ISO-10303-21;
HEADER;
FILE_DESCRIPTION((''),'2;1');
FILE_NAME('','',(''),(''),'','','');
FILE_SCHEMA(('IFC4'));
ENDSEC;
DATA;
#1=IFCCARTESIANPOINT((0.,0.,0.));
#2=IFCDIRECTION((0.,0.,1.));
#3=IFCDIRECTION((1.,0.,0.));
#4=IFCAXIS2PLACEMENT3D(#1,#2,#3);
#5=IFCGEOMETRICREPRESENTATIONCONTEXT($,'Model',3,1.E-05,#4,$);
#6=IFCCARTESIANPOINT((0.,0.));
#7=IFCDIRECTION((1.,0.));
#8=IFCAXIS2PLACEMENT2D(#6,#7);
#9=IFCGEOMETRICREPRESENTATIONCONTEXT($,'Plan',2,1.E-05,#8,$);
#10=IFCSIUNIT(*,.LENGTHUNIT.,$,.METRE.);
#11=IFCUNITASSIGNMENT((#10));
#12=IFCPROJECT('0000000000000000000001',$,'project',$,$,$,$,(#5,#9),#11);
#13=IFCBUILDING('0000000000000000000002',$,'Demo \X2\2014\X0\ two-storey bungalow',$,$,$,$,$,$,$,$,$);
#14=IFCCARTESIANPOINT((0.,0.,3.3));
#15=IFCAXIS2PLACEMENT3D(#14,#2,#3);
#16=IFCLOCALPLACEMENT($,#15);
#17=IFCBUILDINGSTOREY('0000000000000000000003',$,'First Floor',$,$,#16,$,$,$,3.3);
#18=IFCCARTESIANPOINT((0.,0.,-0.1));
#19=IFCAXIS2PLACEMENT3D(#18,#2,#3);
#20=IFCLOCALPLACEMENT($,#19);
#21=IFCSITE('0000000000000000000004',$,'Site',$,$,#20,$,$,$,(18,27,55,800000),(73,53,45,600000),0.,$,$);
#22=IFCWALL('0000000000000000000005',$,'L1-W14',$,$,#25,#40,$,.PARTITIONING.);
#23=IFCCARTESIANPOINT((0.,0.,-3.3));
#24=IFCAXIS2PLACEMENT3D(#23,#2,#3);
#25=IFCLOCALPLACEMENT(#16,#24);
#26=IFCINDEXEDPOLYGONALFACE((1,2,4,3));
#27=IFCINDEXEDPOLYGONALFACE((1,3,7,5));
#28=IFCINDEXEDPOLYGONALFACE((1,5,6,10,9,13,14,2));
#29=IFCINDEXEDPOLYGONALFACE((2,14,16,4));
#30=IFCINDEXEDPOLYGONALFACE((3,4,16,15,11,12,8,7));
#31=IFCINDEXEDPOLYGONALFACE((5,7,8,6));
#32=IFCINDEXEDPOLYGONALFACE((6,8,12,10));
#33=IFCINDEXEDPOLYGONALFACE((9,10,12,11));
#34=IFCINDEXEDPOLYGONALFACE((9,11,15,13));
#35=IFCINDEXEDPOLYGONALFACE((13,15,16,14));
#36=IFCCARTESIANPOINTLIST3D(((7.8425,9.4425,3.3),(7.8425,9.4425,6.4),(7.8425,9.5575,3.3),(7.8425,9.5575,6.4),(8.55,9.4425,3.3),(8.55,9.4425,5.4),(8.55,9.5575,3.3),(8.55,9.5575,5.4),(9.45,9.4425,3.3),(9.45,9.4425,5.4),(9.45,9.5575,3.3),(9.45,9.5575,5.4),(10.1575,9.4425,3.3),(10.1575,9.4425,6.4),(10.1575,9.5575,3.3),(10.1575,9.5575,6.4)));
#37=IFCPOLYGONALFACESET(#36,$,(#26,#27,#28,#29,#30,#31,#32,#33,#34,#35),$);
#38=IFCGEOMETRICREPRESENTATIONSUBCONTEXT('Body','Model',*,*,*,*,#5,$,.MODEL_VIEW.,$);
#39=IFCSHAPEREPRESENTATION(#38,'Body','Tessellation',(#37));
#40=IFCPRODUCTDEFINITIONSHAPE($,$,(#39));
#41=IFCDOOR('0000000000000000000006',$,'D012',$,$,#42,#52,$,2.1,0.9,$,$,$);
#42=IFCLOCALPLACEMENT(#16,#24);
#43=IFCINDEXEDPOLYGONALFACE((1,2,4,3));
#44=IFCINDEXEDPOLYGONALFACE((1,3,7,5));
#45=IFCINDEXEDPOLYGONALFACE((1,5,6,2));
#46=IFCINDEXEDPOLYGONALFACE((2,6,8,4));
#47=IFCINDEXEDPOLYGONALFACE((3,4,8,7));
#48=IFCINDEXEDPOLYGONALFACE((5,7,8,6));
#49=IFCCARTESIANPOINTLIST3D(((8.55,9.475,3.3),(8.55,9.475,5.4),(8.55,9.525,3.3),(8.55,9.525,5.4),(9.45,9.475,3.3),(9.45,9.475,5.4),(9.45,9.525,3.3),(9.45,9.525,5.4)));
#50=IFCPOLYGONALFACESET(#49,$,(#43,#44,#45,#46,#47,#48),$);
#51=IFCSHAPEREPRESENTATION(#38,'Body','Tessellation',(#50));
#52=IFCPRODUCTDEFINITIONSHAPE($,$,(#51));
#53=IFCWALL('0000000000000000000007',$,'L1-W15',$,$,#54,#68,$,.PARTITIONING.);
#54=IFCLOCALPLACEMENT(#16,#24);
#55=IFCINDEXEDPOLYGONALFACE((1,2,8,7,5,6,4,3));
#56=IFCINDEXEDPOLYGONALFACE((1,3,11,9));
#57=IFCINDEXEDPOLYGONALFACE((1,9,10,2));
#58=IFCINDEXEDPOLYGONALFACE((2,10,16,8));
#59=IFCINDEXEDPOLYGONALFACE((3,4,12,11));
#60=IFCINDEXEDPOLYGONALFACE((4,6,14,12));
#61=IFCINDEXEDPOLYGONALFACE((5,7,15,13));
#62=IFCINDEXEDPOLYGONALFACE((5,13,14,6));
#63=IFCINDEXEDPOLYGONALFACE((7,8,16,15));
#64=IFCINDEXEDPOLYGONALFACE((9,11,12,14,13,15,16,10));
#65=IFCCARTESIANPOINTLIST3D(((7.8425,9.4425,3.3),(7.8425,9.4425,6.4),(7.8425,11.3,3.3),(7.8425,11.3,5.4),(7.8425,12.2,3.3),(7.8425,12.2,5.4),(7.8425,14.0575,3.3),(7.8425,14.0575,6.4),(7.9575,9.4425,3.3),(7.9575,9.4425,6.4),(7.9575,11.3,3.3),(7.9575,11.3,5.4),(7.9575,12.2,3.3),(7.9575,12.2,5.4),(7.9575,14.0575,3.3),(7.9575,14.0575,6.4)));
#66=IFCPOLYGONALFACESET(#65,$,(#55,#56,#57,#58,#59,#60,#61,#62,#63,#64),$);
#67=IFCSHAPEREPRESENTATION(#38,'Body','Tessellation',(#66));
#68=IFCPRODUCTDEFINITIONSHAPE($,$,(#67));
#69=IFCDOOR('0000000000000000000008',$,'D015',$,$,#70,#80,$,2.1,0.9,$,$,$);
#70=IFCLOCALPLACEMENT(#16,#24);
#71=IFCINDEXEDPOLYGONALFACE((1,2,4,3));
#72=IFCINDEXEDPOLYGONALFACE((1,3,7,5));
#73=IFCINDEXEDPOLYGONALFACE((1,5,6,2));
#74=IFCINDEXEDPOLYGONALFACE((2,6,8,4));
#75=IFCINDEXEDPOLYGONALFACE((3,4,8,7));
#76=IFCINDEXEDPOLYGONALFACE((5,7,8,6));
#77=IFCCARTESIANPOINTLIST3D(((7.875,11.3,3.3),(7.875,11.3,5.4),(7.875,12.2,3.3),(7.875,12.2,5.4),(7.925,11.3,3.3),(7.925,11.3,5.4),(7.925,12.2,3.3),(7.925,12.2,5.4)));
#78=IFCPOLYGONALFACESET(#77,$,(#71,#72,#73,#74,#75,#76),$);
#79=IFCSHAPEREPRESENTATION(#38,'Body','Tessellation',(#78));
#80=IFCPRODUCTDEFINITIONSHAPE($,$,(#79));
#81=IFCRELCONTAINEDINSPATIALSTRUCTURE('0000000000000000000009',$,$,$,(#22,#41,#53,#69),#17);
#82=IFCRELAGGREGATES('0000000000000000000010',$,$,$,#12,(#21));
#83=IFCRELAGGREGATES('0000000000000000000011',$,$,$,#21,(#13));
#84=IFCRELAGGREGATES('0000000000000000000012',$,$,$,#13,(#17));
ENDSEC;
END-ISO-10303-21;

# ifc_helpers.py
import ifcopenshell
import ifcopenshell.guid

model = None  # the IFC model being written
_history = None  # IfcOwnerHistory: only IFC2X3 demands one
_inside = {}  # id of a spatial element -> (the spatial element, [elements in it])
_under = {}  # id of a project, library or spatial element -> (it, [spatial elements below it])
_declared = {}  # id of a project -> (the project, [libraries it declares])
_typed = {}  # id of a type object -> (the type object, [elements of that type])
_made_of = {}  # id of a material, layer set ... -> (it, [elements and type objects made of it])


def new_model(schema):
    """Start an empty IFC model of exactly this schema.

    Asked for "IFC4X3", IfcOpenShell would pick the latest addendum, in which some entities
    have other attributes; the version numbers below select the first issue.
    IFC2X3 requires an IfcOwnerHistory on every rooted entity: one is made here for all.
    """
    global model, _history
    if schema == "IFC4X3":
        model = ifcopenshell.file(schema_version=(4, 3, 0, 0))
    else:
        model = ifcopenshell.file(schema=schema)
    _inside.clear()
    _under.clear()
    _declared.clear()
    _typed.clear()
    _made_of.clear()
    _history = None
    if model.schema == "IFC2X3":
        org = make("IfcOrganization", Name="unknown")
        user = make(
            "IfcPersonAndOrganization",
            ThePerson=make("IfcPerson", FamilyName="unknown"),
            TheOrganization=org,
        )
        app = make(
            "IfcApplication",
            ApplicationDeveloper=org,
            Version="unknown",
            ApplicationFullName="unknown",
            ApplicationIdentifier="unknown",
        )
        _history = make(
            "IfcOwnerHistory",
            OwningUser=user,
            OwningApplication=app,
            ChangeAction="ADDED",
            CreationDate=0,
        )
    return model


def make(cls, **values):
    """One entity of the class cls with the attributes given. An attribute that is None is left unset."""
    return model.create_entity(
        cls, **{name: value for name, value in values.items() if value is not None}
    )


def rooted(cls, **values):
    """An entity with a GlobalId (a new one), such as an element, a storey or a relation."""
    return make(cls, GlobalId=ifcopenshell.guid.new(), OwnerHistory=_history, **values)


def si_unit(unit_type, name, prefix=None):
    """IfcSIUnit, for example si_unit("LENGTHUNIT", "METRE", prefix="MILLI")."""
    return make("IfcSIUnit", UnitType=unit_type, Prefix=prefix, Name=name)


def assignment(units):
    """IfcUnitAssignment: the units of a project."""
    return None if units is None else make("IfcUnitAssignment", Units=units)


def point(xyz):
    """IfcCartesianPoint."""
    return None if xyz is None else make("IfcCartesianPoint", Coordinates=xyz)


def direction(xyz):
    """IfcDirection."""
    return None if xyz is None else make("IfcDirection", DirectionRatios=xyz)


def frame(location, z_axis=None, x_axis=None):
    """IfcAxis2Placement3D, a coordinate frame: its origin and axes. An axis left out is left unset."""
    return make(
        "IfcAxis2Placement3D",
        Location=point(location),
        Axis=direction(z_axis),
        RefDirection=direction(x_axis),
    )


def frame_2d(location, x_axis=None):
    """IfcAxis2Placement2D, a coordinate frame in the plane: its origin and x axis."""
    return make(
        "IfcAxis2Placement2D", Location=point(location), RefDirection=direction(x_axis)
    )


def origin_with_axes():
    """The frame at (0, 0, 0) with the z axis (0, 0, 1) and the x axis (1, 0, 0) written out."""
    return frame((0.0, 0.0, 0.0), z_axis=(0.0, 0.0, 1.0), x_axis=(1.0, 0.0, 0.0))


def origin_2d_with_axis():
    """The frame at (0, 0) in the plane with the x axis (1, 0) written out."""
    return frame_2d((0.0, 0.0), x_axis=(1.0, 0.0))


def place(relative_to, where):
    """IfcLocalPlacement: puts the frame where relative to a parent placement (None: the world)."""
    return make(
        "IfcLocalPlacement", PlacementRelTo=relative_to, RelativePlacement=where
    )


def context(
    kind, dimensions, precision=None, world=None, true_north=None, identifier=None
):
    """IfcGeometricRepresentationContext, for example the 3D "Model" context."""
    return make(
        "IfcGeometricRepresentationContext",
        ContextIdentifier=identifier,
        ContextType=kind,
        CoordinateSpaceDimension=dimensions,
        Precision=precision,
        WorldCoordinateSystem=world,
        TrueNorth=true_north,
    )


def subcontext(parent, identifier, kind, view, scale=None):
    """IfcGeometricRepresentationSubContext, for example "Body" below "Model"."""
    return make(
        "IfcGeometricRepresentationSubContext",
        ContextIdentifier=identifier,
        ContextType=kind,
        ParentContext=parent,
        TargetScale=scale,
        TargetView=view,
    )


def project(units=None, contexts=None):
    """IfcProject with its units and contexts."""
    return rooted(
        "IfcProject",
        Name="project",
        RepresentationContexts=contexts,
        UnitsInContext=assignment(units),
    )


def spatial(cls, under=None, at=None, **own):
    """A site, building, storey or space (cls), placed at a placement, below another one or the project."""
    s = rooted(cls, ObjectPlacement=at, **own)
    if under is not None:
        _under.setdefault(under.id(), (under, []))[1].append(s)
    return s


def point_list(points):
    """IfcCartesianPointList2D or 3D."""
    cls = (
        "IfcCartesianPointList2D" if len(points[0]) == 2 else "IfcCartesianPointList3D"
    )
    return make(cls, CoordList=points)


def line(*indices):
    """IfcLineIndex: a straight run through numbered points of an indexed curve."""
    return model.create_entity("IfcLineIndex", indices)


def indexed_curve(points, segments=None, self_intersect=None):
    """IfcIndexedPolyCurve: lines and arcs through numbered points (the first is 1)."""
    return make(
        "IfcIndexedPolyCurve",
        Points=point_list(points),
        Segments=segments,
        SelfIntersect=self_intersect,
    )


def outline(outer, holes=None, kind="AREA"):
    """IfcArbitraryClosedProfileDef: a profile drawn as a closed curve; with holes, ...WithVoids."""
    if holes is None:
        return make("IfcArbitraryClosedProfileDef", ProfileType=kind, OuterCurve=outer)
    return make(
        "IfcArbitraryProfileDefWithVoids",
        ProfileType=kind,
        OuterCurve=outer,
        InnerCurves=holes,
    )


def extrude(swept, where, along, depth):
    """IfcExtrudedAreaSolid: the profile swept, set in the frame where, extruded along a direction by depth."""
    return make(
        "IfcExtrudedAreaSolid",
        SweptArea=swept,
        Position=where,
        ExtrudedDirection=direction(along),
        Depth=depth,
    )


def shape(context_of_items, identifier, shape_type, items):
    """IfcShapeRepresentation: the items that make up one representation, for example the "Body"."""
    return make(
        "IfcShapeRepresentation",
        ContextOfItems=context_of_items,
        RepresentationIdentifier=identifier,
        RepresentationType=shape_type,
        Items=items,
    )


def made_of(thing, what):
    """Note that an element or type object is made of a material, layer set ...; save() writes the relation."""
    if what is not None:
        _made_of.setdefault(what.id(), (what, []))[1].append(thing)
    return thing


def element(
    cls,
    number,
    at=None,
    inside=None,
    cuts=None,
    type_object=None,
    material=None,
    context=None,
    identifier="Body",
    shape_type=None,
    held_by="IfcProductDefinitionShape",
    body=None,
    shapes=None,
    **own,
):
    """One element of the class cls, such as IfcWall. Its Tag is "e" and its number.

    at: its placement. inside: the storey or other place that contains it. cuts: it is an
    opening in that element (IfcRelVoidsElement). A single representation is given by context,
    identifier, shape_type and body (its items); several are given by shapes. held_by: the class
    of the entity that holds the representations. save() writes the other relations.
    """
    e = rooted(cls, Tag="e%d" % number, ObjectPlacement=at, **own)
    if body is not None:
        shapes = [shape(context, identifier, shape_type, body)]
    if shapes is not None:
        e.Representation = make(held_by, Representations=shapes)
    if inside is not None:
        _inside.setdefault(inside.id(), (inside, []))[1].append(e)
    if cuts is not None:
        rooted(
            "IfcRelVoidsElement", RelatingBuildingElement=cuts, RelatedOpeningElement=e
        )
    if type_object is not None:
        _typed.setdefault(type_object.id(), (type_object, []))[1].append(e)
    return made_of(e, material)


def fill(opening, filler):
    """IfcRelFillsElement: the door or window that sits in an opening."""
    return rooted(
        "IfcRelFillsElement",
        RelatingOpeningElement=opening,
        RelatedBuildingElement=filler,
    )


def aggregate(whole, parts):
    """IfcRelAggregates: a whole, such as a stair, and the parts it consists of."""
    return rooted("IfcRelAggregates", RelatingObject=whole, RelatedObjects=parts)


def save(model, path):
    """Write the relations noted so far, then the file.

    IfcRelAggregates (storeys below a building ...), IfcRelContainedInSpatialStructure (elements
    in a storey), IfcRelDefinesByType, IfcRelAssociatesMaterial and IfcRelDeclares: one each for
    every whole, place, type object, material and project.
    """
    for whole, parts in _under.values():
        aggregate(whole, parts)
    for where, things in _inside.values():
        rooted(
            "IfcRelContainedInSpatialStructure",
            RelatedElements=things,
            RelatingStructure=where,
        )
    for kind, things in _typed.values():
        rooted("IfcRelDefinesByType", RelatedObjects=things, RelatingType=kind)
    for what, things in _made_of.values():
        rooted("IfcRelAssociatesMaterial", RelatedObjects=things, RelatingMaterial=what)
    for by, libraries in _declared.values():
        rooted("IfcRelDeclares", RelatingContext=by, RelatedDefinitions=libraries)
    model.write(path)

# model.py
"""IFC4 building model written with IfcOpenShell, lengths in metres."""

from ifc_helpers import new_model, si_unit, frame, origin_with_axes, origin_2d_with_axis, place, context, subcontext, project, spatial, line, indexed_curve, outline, extrude, element, fill, save


model = new_model("IFC4")

# Units and contexts
model_context = context("Model", 3, precision=1e-05, world=origin_with_axes())
plan_context = context("Plan", 2, precision=1e-05, world=origin_2d_with_axis())
body_context = subcontext(model_context, "Body", "Model", "MODEL_VIEW")
ifc_project = project(units=[si_unit("LENGTHUNIT", "METRE")], contexts=[model_context, plan_context])

# Site, building, storey
site_placement = place(None, frame((0.0, 0.0, -0.1), z_axis=(0.0, 0.0, 1.0), x_axis=(1.0, 0.0, 0.0)))
site = spatial("IfcSite", under=ifc_project, at=site_placement, Name="Site", RefLatitude=(18, 27, 55, 800000), RefLongitude=(73, 53, 45, 600000), RefElevation=0.0)
building = spatial("IfcBuilding", under=site, Name="Demo — two-storey bungalow")
storey_placement = place(None, frame((0.0, 0.0, 3.3), z_axis=(0.0, 0.0, 1.0), x_axis=(1.0, 0.0, 0.0)))
storey = spatial("IfcBuildingStorey", under=building, at=storey_placement, Name="First Floor", Elevation=3.3)

# Walls, openings, doors
wall_1_placement = place(storey_placement, frame((0.0, 0.0, -3.3), z_axis=(0.0, 0.0, 1.0), x_axis=(1.0, 0.0, 0.0)))
wall_1 = element("IfcWall", 1, at=wall_1_placement, inside=storey, Name="L1-W14", PredefinedType="PARTITIONING", context=body_context, shape_type="SweptSolid", body=[
    extrude(outline(indexed_curve([(10.1575, 9.4425), (7.8425, 9.4425), (7.8425, 9.5575), (10.1575, 9.5575)], segments=[line(1, 2, 3, 4, 1)])), frame((0.0, 0.0, 3.3), z_axis=(0.0, 0.0, 1.0), x_axis=(1.0, 0.0, 0.0)), (0.0, 0.0, 1.0), 3.1),
])
opening_1_placement = place(wall_1_placement, origin_with_axes())
opening_1 = element("IfcOpeningElement", 2, at=opening_1_placement, cuts=wall_1, context=body_context, shape_type="SweptSolid", body=[
    extrude(outline(indexed_curve([(9.45, 9.3925), (8.55, 9.3925), (8.55, 9.6075), (9.45, 9.6075)], segments=[line(1, 2, 3, 4, 1)])), frame((0.0, 0.0, 3.3), z_axis=(0.0, 0.0, 1.0), x_axis=(1.0, 0.0, 0.0)), (0.0, 0.0, 1.0), 2.1),
])
door_1_placement = place(storey_placement, frame((0.0, 0.0, -3.3), z_axis=(0.0, 0.0, 1.0), x_axis=(1.0, 0.0, 0.0)))
door_1 = element("IfcDoor", 3, at=door_1_placement, inside=storey, Name="D012", OverallHeight=2.1, OverallWidth=0.9, context=body_context, shape_type="SweptSolid", body=[
    extrude(outline(indexed_curve([(9.45, 9.475), (8.55, 9.475), (8.55, 9.525), (9.45, 9.525)], segments=[line(1, 2, 3, 4, 1)])), frame((0.0, 0.0, 3.3), z_axis=(0.0, 0.0, 1.0), x_axis=(1.0, 0.0, 0.0)), (0.0, 0.0, 1.0), 2.1),
])
fill(opening_1, door_1)
wall_2_placement = place(storey_placement, frame((0.0, 0.0, -3.3), z_axis=(0.0, 0.0, 1.0), x_axis=(1.0, 0.0, 0.0)))
wall_2 = element("IfcWall", 4, at=wall_2_placement, inside=storey, Name="L1-W15", PredefinedType="PARTITIONING", context=body_context, shape_type="SweptSolid", body=[
    extrude(outline(indexed_curve([(7.8425, 9.4425), (7.8425, 14.0575), (7.9575, 14.0575), (7.9575, 9.4425)], segments=[line(1, 2, 3, 4, 1)])), frame((0.0, 0.0, 3.3), z_axis=(0.0, 0.0, 1.0), x_axis=(1.0, 0.0, 0.0)), (0.0, 0.0, 1.0), 3.1),
])
opening_2_placement = place(wall_2_placement, origin_with_axes())
opening_2 = element("IfcOpeningElement", 5, at=opening_2_placement, cuts=wall_2, context=body_context, shape_type="SweptSolid", body=[
    extrude(outline(indexed_curve([(7.7925, 11.3), (7.7925, 12.2), (8.0075, 12.2), (8.0075, 11.3)], segments=[line(1, 2, 3, 4, 1)])), frame((0.0, 0.0, 3.3), z_axis=(0.0, 0.0, 1.0), x_axis=(1.0, 0.0, 0.0)), (0.0, 0.0, 1.0), 2.1),
])
door_2_placement = place(storey_placement, frame((0.0, 0.0, -3.3), z_axis=(0.0, 0.0, 1.0), x_axis=(1.0, 0.0, 0.0)))
door_2 = element("IfcDoor", 6, at=door_2_placement, inside=storey, Name="D015", OverallHeight=2.1, OverallWidth=0.9, context=body_context, shape_type="SweptSolid", body=[
    extrude(outline(indexed_curve([(7.875, 11.3), (7.875, 12.2), (7.925, 12.2), (7.925, 11.3)], segments=[line(1, 2, 3, 4, 1)])), frame((0.0, 0.0, 3.3), z_axis=(0.0, 0.0, 1.0), x_axis=(1.0, 0.0, 0.0)), (0.0, 0.0, 1.0), 2.1),
])
fill(opening_2, door_2)

save(model, "model.ifc")
